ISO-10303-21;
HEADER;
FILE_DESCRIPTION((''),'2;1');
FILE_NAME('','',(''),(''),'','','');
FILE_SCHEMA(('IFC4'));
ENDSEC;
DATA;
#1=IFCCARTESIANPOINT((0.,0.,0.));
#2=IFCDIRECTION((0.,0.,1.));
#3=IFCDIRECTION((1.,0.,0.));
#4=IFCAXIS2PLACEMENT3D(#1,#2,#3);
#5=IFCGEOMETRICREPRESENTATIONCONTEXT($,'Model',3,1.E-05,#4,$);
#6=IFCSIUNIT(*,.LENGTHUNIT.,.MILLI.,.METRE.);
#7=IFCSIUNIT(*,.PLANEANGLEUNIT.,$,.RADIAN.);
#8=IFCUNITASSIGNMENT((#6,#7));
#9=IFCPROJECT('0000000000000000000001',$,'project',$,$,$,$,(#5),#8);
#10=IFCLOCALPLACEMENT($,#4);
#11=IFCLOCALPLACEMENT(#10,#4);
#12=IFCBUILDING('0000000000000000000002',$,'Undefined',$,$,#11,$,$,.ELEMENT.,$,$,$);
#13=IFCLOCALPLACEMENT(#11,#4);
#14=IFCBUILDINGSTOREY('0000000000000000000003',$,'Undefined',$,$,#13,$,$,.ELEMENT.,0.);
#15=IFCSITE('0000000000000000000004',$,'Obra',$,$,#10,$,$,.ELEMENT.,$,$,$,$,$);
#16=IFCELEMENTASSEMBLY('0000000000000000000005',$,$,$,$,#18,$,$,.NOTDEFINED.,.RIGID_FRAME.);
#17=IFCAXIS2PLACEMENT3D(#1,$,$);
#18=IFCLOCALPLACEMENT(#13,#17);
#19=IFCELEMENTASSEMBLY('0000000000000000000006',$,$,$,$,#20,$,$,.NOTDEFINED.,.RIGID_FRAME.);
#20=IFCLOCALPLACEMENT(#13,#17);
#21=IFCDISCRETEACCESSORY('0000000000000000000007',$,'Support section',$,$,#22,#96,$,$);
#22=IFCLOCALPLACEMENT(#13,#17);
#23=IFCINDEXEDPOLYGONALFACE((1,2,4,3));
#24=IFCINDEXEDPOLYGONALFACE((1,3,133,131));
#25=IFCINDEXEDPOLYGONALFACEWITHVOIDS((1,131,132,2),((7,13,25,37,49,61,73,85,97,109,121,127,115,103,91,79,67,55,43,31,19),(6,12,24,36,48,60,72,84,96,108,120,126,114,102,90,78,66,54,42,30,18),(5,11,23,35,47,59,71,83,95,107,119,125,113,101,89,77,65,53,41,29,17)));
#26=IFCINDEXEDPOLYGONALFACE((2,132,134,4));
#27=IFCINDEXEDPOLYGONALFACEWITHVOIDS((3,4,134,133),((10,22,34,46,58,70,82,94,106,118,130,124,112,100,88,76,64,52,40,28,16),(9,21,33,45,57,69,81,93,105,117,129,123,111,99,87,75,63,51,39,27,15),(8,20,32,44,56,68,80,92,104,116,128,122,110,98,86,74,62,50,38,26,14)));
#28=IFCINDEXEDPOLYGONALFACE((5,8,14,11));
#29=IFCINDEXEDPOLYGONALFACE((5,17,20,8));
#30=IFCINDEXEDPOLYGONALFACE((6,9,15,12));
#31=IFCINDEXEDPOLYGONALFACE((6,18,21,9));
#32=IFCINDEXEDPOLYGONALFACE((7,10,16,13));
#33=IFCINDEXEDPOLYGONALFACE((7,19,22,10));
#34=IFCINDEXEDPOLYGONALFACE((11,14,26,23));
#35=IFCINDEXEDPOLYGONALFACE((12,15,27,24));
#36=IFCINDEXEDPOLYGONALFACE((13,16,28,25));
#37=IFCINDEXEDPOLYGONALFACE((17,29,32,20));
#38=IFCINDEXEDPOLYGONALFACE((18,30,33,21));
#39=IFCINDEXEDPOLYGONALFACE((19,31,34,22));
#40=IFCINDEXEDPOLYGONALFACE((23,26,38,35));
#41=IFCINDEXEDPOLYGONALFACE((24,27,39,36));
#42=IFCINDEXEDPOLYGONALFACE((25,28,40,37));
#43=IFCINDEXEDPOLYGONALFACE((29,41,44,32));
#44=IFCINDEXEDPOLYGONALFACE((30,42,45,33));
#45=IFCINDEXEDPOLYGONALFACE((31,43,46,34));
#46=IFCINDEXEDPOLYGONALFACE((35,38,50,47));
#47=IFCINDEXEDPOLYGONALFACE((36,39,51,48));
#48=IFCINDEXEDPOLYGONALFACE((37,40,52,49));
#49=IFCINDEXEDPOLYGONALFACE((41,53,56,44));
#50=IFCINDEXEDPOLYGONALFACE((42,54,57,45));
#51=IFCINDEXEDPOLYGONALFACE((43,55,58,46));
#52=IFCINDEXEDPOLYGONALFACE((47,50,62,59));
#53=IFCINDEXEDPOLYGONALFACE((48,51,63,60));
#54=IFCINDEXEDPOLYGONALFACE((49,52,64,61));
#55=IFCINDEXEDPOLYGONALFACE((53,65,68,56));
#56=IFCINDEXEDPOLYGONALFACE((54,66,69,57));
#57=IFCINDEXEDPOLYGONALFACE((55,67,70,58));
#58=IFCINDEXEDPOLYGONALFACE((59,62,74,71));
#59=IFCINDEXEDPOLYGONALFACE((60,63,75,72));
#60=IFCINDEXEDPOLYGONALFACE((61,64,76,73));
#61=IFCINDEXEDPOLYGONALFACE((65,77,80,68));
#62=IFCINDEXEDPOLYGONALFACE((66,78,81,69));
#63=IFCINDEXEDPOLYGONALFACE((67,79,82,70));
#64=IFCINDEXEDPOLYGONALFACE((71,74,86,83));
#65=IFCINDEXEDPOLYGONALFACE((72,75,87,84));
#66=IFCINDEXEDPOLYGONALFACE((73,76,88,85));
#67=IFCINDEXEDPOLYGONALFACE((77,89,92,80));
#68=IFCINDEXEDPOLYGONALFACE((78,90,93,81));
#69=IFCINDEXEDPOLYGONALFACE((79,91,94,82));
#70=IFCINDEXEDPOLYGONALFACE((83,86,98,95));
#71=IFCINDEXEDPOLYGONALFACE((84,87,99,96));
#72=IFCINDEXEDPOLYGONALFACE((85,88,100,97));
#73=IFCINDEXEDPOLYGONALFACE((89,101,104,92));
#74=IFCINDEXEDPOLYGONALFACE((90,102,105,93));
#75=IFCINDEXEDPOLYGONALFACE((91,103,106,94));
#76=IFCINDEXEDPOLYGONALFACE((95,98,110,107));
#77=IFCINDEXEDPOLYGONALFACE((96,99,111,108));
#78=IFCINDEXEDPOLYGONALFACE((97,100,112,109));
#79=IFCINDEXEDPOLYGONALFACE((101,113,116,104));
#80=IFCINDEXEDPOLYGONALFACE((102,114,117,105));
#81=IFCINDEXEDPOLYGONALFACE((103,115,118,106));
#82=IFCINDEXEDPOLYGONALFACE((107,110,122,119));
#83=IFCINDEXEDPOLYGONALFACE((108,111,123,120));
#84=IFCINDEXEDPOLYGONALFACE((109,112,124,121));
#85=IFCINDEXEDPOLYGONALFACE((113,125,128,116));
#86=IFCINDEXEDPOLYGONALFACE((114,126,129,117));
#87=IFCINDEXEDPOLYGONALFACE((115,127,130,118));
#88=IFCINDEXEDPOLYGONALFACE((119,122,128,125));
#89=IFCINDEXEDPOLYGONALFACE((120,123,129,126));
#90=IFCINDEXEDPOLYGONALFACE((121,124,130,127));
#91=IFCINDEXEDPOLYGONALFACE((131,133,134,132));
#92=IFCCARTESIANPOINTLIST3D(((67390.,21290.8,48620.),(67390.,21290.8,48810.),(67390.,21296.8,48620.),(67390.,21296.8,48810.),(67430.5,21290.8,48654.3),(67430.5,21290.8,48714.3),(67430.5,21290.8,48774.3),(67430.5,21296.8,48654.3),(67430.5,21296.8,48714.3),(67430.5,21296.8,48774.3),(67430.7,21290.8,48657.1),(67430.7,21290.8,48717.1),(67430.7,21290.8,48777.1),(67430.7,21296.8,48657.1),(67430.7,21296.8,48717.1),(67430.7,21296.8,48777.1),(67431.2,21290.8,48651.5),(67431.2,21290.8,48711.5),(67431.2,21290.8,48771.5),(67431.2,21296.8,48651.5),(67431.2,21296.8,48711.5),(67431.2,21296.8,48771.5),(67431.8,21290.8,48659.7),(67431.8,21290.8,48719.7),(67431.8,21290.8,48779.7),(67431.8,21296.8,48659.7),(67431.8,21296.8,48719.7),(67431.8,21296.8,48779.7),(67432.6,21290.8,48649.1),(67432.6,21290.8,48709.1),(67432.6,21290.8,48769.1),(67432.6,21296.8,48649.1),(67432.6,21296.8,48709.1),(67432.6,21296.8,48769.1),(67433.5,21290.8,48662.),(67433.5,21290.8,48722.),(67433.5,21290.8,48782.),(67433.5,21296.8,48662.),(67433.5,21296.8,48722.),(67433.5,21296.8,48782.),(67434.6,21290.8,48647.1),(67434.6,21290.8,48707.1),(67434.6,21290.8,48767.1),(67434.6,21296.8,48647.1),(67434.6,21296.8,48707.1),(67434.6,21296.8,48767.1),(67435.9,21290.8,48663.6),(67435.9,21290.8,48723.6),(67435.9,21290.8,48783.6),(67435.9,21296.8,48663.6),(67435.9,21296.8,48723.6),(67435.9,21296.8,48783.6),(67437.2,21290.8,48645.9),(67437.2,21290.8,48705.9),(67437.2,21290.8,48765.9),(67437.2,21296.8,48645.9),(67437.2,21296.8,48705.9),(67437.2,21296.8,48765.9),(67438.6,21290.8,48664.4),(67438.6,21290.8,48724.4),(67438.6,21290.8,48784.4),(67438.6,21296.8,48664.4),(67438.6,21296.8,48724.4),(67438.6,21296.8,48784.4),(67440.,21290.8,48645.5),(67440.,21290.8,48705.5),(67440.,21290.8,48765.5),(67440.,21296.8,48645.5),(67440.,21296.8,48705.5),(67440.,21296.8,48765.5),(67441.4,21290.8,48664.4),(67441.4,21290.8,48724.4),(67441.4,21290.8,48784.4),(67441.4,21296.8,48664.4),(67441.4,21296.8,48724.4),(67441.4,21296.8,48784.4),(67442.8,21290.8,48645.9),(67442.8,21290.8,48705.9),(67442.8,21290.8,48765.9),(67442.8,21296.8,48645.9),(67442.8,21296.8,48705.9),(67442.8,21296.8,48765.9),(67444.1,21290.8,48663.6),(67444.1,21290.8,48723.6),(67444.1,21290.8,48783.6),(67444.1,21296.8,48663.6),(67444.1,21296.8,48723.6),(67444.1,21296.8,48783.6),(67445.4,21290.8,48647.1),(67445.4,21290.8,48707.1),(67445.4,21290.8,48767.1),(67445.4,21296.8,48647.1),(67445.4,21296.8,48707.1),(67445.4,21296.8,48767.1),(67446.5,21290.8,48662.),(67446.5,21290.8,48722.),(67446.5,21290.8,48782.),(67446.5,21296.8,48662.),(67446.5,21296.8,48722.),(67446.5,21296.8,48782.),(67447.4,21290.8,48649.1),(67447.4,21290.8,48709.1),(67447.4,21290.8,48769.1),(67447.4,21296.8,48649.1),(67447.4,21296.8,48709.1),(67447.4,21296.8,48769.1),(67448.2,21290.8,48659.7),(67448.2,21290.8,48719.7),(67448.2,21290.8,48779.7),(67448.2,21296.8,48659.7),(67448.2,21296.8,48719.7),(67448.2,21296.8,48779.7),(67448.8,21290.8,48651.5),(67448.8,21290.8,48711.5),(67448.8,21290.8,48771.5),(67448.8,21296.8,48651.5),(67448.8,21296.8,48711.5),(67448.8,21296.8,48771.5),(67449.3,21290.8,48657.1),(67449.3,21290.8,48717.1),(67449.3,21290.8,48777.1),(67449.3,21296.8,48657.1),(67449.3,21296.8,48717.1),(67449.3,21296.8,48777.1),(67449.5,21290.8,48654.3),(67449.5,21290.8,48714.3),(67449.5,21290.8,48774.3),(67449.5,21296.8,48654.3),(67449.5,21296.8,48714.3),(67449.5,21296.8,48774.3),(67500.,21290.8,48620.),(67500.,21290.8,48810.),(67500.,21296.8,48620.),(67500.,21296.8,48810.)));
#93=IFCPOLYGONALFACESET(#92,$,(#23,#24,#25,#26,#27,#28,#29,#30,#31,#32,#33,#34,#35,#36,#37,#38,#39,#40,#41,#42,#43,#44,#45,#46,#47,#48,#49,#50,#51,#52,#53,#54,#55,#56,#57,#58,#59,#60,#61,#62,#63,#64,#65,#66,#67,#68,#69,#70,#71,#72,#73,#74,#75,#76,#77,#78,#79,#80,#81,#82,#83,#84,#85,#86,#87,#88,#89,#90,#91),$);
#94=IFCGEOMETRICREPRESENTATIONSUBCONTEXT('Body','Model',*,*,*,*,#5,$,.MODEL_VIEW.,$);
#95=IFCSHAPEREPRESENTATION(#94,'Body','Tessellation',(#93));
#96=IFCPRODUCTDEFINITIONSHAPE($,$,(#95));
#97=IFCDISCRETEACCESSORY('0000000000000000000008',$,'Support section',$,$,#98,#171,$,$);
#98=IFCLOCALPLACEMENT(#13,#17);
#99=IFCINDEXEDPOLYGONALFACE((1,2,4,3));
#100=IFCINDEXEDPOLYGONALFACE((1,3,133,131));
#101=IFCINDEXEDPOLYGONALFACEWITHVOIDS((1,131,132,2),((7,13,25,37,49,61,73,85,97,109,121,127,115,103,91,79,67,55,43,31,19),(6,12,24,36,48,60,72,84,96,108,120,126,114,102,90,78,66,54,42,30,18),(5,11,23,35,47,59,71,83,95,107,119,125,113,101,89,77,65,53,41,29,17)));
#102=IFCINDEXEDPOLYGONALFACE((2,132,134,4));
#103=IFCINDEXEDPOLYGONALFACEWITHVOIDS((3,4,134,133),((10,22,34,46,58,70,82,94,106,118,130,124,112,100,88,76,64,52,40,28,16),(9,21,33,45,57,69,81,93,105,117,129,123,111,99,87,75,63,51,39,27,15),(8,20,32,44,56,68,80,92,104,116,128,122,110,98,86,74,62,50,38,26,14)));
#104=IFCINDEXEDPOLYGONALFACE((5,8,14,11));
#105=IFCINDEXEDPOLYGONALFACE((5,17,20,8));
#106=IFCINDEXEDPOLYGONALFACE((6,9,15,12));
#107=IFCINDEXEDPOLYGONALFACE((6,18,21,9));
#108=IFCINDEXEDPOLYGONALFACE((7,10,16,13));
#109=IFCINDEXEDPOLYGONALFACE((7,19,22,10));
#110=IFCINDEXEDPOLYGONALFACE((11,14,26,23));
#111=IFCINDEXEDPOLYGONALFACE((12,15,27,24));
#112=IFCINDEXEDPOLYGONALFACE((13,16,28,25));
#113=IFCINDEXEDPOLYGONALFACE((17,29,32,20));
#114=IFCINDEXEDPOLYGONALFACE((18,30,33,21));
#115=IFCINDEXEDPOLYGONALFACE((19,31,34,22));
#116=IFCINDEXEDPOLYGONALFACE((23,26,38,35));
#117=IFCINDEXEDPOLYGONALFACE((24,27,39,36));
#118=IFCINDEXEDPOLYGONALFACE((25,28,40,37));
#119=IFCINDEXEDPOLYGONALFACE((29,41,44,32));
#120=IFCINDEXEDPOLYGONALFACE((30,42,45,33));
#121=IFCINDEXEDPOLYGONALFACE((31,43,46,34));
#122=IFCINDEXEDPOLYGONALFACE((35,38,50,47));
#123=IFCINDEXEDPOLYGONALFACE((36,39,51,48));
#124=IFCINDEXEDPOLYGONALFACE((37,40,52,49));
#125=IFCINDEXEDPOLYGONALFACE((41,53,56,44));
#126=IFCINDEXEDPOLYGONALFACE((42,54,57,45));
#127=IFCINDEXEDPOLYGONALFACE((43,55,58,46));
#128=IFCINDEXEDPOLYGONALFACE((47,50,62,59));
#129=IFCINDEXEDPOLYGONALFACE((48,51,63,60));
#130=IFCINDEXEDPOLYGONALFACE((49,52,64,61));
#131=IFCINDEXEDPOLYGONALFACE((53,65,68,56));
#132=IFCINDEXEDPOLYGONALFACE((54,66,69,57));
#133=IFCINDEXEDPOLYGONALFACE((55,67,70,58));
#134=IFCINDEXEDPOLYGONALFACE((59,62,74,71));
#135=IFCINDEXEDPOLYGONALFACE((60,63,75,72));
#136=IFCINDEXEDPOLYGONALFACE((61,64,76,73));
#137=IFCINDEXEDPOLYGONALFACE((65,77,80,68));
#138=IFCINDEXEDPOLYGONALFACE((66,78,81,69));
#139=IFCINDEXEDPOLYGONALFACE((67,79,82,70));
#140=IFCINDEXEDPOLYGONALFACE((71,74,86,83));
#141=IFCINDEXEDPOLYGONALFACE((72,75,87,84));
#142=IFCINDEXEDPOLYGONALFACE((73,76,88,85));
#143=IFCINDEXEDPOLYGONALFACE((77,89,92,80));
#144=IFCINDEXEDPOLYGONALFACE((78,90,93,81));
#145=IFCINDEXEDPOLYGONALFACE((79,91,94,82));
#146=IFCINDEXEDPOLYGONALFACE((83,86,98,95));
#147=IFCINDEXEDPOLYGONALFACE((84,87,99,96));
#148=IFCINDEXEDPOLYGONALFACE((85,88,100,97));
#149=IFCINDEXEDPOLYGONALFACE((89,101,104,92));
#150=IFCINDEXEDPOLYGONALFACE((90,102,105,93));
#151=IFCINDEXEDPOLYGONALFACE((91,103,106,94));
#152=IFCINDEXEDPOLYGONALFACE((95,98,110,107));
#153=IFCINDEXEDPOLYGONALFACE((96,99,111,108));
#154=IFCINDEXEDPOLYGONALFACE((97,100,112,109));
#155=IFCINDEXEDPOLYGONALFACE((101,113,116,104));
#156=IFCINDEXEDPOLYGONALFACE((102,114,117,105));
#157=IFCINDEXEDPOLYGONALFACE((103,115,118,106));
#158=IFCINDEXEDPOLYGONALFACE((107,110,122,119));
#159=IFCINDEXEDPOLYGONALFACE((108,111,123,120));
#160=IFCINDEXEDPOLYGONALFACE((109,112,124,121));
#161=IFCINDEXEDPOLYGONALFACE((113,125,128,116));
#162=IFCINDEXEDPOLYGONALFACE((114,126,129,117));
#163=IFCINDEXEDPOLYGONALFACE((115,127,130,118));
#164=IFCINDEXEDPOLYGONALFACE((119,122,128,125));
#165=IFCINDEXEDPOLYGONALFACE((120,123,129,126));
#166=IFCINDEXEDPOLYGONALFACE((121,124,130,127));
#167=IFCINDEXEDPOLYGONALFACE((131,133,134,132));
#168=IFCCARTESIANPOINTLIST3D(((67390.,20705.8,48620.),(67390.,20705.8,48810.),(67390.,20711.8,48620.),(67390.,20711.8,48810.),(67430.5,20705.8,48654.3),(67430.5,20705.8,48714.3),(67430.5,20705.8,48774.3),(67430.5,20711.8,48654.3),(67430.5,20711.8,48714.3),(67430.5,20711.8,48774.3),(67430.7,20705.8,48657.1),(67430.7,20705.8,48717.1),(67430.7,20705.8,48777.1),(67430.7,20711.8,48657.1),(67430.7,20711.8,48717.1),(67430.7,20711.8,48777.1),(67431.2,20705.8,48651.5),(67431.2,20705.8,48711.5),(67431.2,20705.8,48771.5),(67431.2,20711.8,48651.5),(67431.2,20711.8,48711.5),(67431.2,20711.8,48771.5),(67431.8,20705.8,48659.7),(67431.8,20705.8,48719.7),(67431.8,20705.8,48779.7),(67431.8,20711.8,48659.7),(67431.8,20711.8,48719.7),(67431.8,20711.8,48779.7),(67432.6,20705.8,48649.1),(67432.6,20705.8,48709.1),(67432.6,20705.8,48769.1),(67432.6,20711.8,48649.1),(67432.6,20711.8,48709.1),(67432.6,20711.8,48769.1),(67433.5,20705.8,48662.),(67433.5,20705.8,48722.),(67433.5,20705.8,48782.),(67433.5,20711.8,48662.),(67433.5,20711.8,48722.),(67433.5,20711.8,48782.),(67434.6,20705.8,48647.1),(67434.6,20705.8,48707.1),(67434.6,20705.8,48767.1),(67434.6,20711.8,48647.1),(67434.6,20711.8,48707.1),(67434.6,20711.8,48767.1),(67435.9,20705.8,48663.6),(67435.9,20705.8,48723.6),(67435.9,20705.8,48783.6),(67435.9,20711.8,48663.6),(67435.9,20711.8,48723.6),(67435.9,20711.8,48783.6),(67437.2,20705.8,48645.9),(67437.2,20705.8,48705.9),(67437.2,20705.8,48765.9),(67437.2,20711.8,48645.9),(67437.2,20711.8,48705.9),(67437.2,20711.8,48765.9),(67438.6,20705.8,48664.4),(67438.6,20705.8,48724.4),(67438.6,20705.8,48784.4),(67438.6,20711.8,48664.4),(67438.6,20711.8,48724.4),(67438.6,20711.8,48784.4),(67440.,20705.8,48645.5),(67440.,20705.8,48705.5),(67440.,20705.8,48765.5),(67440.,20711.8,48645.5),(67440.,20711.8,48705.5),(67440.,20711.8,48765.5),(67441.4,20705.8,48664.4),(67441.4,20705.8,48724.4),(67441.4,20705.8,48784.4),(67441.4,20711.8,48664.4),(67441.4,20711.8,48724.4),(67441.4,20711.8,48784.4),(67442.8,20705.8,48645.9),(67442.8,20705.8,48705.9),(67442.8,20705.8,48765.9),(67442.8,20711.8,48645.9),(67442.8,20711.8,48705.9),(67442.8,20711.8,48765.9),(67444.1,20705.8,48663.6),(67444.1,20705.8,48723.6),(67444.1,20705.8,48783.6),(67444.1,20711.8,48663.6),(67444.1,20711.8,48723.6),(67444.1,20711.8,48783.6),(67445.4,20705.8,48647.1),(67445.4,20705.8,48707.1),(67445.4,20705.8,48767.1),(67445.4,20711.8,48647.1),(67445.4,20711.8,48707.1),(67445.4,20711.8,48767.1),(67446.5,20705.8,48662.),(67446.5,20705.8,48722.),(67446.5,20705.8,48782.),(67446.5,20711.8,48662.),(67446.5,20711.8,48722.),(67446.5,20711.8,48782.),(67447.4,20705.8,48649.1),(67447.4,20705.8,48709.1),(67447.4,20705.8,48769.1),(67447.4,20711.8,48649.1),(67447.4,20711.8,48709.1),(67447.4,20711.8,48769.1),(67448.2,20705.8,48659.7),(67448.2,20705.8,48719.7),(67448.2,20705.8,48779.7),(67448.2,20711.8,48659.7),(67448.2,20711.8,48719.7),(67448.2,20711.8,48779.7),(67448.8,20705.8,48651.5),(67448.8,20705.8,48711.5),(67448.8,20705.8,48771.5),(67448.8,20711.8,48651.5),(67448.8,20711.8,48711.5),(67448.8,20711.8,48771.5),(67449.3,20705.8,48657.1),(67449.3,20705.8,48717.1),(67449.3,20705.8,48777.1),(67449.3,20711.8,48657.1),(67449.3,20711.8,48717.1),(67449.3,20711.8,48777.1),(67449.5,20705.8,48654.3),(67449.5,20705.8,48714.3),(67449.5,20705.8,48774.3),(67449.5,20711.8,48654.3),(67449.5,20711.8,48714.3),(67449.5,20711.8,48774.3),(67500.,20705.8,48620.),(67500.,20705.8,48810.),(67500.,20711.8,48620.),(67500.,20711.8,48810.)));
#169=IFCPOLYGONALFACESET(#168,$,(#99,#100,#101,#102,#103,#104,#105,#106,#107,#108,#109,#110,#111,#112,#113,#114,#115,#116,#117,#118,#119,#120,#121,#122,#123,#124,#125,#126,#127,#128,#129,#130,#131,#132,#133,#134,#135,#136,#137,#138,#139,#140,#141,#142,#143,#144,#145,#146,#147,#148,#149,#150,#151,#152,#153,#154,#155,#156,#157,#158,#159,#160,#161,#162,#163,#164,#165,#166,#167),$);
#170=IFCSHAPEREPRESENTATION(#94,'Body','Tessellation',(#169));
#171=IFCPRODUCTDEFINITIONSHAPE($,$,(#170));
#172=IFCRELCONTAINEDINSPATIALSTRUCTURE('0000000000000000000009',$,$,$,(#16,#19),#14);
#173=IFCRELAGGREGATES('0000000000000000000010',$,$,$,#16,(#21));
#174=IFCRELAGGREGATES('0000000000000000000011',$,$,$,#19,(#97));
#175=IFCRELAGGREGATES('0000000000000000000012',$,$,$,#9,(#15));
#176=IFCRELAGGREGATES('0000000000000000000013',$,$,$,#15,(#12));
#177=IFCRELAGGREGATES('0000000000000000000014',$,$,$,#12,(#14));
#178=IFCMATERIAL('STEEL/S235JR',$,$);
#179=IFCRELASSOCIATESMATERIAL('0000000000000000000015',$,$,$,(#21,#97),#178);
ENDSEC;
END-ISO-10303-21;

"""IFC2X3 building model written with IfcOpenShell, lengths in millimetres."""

from ifc_helpers import new_model, si_unit, frame, origin_with_axes, origin_2d_with_axis, place, context, subcontext, project, spatial, rectangle, circle, extrude, source, transform, mapped, material, element, aggregate, save


model = new_model("IFC2X3")

# Units and contexts
model_context = context("Model", 3, precision=1e-05, world=origin_with_axes())
body_context = subcontext(model_context, "Body", "Model", "MODEL_VIEW")
ifc_project = project(units=[si_unit("LENGTHUNIT", "METRE", prefix="MILLI"), si_unit("PLANEANGLEUNIT", "RADIAN")], contexts=[model_context])

# Site, building, storey
site_placement = place(None, origin_with_axes())
site = spatial("IfcSite", under=ifc_project, at=site_placement, Name="Obra", CompositionType="ELEMENT")
building_placement = place(site_placement, origin_with_axes())
building = spatial("IfcBuilding", under=site, at=building_placement, Name="Undefined", CompositionType="ELEMENT")
storey_placement = place(building_placement, origin_with_axes())
storey = spatial("IfcBuildingStorey", under=building, at=storey_placement, Name="Undefined", CompositionType="ELEMENT", Elevation=0.0)

# Element assemblies
assembly_1_placement = place(storey_placement, origin_with_axes())
assembly_1 = element("IfcElementAssembly", 1, at=assembly_1_placement, inside=storey, AssemblyPlace="NOTDEFINED", PredefinedType="RIGID_FRAME")
ifc_material_1 = material(Name="STEEL/S235JR")
assembly_2_placement = place(storey_placement, origin_with_axes())
assembly_2 = element("IfcElementAssembly", 2, at=assembly_2_placement, inside=storey, AssemblyPlace="NOTDEFINED", PredefinedType="RIGID_FRAME")

# Discrete accessories, openings
discrete_accessory_1_placement = place(assembly_1_placement, frame((67445.0, 21293.8, 48620.0), z_axis=(0.0, 0.0, 1.0), x_axis=(1.0, 0.0, 0.0)))
discrete_accessory_1 = element("IfcDiscreteAccessory", 3, at=discrete_accessory_1_placement, material=ifc_material_1, Name="Support section", context=body_context, shape_type="SweptSolid", body=[
    extrude(rectangle(XDim=6.0, YDim=110.0, at=origin_2d_with_axis()), frame((0.0, 0.0, 190.0), z_axis=(0.0, 0.0, -1.0), x_axis=(0.0, 1.0, 0.0)), (0.0, 0.0, 1.0), 190.0),
])
shared_shape_1 = source(origin_with_axes(), body_context, "Body", "SweptSolid", [
    extrude(circle(Radius=9.5, at=origin_2d_with_axis()), frame((0.0, -9.2, 0.0), z_axis=(0.0, 1.0, 0.0), x_axis=(1.0, 0.0, 0.0)), (0.0, 0.0, 1.0), 6.2),
])
opening_1_placement = place(assembly_1_placement, frame((67490.0, 21287.7, 48835.0), z_axis=(-1.0, 0.0, 0.0), x_axis=(0.0, 0.0, -1.0)))
element("IfcOpeningElement", 4, at=opening_1_placement, cuts=discrete_accessory_1, ObjectType="Opening", context=body_context, shape_type="MappedRepresentation", body=[
    mapped(shared_shape_1, transform((60.0, 0.0, 50.0))),
    mapped(shared_shape_1, transform((120.0, 0.0, 50.0))),
    mapped(shared_shape_1, transform((180.0, 0.0, 50.0))),
])
aggregate(assembly_1, [discrete_accessory_1])
discrete_accessory_2_placement = place(assembly_2_placement, frame((67445.0, 20708.8, 48620.0), z_axis=(0.0, 0.0, 1.0), x_axis=(1.0, 0.0, 0.0)))
discrete_accessory_2 = element("IfcDiscreteAccessory", 5, at=discrete_accessory_2_placement, material=ifc_material_1, Name="Support section", context=body_context, shape_type="SweptSolid", body=[
    extrude(rectangle(XDim=6.0, YDim=110.0, at=origin_2d_with_axis()), frame((0.0, 0.0, 190.0), z_axis=(0.0, 0.0, -1.0), x_axis=(0.0, 1.0, 0.0)), (0.0, 0.0, 1.0), 190.0),
])
opening_2_placement = place(assembly_2_placement, frame((67490.0, 20702.7, 48835.0), z_axis=(-1.0, 0.0, 0.0), x_axis=(0.0, 0.0, -1.0)))
element("IfcOpeningElement", 6, at=opening_2_placement, cuts=discrete_accessory_2, ObjectType="Opening", context=body_context, shape_type="MappedRepresentation", body=[
    mapped(shared_shape_1, transform((60.0, 0.0, 50.0))),
    mapped(shared_shape_1, transform((120.0, 0.0, 50.0))),
    mapped(shared_shape_1, transform((180.0, 0.0, 50.0))),
])
aggregate(assembly_2, [discrete_accessory_2])

save(model, "model.ifc")
